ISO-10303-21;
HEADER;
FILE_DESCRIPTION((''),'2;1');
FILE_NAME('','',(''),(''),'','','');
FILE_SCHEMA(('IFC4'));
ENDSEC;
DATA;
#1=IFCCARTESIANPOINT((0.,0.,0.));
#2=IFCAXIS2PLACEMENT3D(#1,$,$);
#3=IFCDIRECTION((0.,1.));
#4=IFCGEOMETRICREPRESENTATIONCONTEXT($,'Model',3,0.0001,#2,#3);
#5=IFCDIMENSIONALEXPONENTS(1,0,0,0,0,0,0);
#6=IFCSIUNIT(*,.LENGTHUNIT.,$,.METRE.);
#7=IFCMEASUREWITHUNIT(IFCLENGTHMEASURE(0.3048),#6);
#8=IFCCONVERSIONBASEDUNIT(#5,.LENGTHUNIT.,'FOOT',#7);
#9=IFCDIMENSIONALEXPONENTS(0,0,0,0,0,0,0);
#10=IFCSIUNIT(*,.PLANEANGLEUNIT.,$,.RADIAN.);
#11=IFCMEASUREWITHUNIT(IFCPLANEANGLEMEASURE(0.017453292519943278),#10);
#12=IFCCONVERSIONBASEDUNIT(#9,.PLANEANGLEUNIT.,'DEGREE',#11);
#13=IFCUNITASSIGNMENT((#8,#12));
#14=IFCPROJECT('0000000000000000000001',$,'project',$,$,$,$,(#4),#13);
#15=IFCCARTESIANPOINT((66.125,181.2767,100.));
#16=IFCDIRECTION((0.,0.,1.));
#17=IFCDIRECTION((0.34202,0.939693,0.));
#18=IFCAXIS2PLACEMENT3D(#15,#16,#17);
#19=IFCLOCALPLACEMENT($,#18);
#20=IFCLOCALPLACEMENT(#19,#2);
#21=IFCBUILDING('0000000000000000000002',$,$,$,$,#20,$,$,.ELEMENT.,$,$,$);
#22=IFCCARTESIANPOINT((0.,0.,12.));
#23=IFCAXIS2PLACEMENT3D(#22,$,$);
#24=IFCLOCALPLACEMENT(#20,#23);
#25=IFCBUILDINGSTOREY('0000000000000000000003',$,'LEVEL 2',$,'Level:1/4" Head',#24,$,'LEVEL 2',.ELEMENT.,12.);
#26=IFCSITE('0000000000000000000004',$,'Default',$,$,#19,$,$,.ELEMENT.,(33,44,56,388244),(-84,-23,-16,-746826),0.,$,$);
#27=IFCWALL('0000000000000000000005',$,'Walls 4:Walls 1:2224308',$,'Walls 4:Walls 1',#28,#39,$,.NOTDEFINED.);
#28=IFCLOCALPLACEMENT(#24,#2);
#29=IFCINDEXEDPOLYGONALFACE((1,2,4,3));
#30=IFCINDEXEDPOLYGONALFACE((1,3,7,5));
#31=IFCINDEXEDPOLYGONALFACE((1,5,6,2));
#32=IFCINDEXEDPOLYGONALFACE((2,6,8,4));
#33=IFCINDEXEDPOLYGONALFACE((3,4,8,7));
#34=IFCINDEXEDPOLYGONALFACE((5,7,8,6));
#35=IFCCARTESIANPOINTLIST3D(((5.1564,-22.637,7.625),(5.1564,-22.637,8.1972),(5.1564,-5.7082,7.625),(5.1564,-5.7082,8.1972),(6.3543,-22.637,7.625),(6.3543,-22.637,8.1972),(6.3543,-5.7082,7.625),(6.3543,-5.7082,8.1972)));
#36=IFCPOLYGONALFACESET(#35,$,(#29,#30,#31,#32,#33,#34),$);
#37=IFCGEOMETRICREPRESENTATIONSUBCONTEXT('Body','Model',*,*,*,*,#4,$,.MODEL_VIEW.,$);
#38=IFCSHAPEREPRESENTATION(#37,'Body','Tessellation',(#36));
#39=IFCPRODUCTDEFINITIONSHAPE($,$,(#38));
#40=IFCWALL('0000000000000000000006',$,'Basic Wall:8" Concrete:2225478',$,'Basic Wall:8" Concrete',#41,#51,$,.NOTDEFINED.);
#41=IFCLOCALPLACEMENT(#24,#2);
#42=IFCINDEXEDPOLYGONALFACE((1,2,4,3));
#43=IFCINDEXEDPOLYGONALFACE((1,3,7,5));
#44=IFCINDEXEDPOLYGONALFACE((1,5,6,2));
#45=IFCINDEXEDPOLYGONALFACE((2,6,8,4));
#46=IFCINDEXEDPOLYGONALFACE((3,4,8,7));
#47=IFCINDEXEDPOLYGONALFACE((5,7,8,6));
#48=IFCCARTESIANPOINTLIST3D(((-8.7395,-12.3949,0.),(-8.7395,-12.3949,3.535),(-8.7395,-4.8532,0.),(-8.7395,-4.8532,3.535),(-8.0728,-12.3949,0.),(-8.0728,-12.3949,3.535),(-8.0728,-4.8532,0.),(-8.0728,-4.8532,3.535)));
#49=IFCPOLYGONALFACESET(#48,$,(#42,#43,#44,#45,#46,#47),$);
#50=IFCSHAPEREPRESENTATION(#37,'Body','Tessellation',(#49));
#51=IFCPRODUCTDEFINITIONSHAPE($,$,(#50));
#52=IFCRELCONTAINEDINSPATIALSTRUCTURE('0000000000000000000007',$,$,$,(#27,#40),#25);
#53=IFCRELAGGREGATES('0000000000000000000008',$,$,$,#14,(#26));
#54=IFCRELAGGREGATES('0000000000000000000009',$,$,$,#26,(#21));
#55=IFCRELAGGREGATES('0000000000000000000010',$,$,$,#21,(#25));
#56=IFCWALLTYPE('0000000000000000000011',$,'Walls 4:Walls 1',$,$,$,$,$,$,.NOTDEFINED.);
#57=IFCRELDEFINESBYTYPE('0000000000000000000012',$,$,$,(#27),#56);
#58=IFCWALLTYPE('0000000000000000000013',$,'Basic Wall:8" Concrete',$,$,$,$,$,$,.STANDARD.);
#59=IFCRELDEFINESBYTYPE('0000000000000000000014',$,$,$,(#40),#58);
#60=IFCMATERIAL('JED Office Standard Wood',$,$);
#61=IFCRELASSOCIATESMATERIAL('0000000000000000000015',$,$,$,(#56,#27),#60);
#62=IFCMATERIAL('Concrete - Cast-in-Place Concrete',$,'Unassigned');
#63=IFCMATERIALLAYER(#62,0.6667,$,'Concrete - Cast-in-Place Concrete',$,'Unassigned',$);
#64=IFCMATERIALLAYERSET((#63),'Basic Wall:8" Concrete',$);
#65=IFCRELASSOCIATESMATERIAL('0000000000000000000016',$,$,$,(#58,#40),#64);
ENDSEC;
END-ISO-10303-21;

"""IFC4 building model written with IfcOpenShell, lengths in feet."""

from ifc_helpers import new_model, entity, si_unit, converted_unit, direction, frame, frame_2d, origin, place, context, subcontext, project, spatial, rectangle, extrude, material, layer, layer_set, layer_usage, type_object, element, save


model = new_model("IFC4")

# Units and contexts
model_context = context("Model", 3, precision=0.0001, world=origin(), true_north=direction((0.0, 1.0)))
body_context = subcontext(model_context, "Body", "Model", "MODEL_VIEW")
ifc_project = project(units=[converted_unit("LENGTHUNIT", "FOOT", entity("IfcLengthMeasure", 0.3048), si_unit("LENGTHUNIT", "METRE"), dimensions=[1, 0, 0, 0, 0, 0, 0]), converted_unit("PLANEANGLEUNIT", "DEGREE", entity("IfcPlaneAngleMeasure", 0.017453292519943278), si_unit("PLANEANGLEUNIT", "RADIAN"), dimensions=[0, 0, 0, 0, 0, 0, 0])], contexts=[model_context])

# Site, building, storey
site_placement = place(None, frame((66.125, 181.2767, 100.0), z_axis=(0.0, 0.0, 1.0), x_axis=(0.34202, 0.939693, 0.0)))
site = spatial("IfcSite", under=ifc_project, at=site_placement, Name="Default", CompositionType="ELEMENT", RefLatitude=(33, 44, 56, 388244), RefLongitude=(-84, -23, -16, -746826), RefElevation=0.0)
building_placement = place(site_placement, origin())
building = spatial("IfcBuilding", under=site, at=building_placement, CompositionType="ELEMENT")
storey_placement = place(building_placement, frame((0.0, 0.0, 12.0)))
storey = spatial("IfcBuildingStorey", under=building, at=storey_placement, Name="LEVEL 2", ObjectType="Level:1/4\" Head", LongName="LEVEL 2", CompositionType="ELEMENT", Elevation=12.0)

# Walls
ifc_material_1 = material(Name="JED Office Standard Wood")
wall_type_1 = type_object("IfcWallType", Name="Walls 4:Walls 1", PredefinedType="NOTDEFINED", material=ifc_material_1)
wall_1_placement = place(storey_placement, frame((5.1564, -22.637, 7.625), z_axis=(0.0, 0.0, 1.0), x_axis=(0.0, 1.0, 0.0)))
element("IfcWall", 1, at=wall_1_placement, inside=storey, type_object=wall_type_1, material=ifc_material_1, Name="Walls 4:Walls 1:2224308", ObjectType="Walls 4:Walls 1", PredefinedType="NOTDEFINED", context=body_context, shape_type="SweptSolid", body=[
    extrude(rectangle(XDim=1.1979, YDim=16.9288, at=frame_2d((0.0, 0.0), x_axis=(1.0, 0.0))), frame((8.4644, -0.599, 0.0), z_axis=(0.0, 0.0, 1.0), x_axis=(0.0, 1.0, 0.0)), (0.0, 0.0, 1.0), 0.5722),
])
ifc_material_2 = material(Name="Concrete - Cast-in-Place Concrete", Category="Unassigned")
ifc_layer_1 = layer(ifc_material_2, 0.6667, Name="Concrete - Cast-in-Place Concrete", Category="Unassigned")
ifc_layer_set_1 = layer_set([ifc_layer_1], Name="Basic Wall:8\" Concrete")
ifc_layer_usage_1 = layer_usage(ifc_layer_set_1, "AXIS2", "NEGATIVE", 0.3333)
wall_type_2 = type_object("IfcWallType", Name="Basic Wall:8\" Concrete", PredefinedType="STANDARD", material=ifc_layer_set_1)
wall_2_placement = place(storey_placement, frame((-8.4061, -4.8532, 0.0), z_axis=(0.0, 0.0, 1.0), x_axis=(0.0, -1.0, 0.0)))
element("IfcWall", 2, at=wall_2_placement, inside=storey, type_object=wall_type_2, material=ifc_layer_usage_1, Name="Basic Wall:8\" Concrete:2225478", ObjectType="Basic Wall:8\" Concrete", PredefinedType="NOTDEFINED", context=body_context, shape_type="SweptSolid", body=[
    extrude(rectangle(XDim=7.5417, YDim=0.6667, at=frame_2d((3.7708, 0.0), x_axis=(-1.0, 0.0))), origin(), (0.0, 0.0, 1.0), 3.535),
])

save(model, "model.ifc")
